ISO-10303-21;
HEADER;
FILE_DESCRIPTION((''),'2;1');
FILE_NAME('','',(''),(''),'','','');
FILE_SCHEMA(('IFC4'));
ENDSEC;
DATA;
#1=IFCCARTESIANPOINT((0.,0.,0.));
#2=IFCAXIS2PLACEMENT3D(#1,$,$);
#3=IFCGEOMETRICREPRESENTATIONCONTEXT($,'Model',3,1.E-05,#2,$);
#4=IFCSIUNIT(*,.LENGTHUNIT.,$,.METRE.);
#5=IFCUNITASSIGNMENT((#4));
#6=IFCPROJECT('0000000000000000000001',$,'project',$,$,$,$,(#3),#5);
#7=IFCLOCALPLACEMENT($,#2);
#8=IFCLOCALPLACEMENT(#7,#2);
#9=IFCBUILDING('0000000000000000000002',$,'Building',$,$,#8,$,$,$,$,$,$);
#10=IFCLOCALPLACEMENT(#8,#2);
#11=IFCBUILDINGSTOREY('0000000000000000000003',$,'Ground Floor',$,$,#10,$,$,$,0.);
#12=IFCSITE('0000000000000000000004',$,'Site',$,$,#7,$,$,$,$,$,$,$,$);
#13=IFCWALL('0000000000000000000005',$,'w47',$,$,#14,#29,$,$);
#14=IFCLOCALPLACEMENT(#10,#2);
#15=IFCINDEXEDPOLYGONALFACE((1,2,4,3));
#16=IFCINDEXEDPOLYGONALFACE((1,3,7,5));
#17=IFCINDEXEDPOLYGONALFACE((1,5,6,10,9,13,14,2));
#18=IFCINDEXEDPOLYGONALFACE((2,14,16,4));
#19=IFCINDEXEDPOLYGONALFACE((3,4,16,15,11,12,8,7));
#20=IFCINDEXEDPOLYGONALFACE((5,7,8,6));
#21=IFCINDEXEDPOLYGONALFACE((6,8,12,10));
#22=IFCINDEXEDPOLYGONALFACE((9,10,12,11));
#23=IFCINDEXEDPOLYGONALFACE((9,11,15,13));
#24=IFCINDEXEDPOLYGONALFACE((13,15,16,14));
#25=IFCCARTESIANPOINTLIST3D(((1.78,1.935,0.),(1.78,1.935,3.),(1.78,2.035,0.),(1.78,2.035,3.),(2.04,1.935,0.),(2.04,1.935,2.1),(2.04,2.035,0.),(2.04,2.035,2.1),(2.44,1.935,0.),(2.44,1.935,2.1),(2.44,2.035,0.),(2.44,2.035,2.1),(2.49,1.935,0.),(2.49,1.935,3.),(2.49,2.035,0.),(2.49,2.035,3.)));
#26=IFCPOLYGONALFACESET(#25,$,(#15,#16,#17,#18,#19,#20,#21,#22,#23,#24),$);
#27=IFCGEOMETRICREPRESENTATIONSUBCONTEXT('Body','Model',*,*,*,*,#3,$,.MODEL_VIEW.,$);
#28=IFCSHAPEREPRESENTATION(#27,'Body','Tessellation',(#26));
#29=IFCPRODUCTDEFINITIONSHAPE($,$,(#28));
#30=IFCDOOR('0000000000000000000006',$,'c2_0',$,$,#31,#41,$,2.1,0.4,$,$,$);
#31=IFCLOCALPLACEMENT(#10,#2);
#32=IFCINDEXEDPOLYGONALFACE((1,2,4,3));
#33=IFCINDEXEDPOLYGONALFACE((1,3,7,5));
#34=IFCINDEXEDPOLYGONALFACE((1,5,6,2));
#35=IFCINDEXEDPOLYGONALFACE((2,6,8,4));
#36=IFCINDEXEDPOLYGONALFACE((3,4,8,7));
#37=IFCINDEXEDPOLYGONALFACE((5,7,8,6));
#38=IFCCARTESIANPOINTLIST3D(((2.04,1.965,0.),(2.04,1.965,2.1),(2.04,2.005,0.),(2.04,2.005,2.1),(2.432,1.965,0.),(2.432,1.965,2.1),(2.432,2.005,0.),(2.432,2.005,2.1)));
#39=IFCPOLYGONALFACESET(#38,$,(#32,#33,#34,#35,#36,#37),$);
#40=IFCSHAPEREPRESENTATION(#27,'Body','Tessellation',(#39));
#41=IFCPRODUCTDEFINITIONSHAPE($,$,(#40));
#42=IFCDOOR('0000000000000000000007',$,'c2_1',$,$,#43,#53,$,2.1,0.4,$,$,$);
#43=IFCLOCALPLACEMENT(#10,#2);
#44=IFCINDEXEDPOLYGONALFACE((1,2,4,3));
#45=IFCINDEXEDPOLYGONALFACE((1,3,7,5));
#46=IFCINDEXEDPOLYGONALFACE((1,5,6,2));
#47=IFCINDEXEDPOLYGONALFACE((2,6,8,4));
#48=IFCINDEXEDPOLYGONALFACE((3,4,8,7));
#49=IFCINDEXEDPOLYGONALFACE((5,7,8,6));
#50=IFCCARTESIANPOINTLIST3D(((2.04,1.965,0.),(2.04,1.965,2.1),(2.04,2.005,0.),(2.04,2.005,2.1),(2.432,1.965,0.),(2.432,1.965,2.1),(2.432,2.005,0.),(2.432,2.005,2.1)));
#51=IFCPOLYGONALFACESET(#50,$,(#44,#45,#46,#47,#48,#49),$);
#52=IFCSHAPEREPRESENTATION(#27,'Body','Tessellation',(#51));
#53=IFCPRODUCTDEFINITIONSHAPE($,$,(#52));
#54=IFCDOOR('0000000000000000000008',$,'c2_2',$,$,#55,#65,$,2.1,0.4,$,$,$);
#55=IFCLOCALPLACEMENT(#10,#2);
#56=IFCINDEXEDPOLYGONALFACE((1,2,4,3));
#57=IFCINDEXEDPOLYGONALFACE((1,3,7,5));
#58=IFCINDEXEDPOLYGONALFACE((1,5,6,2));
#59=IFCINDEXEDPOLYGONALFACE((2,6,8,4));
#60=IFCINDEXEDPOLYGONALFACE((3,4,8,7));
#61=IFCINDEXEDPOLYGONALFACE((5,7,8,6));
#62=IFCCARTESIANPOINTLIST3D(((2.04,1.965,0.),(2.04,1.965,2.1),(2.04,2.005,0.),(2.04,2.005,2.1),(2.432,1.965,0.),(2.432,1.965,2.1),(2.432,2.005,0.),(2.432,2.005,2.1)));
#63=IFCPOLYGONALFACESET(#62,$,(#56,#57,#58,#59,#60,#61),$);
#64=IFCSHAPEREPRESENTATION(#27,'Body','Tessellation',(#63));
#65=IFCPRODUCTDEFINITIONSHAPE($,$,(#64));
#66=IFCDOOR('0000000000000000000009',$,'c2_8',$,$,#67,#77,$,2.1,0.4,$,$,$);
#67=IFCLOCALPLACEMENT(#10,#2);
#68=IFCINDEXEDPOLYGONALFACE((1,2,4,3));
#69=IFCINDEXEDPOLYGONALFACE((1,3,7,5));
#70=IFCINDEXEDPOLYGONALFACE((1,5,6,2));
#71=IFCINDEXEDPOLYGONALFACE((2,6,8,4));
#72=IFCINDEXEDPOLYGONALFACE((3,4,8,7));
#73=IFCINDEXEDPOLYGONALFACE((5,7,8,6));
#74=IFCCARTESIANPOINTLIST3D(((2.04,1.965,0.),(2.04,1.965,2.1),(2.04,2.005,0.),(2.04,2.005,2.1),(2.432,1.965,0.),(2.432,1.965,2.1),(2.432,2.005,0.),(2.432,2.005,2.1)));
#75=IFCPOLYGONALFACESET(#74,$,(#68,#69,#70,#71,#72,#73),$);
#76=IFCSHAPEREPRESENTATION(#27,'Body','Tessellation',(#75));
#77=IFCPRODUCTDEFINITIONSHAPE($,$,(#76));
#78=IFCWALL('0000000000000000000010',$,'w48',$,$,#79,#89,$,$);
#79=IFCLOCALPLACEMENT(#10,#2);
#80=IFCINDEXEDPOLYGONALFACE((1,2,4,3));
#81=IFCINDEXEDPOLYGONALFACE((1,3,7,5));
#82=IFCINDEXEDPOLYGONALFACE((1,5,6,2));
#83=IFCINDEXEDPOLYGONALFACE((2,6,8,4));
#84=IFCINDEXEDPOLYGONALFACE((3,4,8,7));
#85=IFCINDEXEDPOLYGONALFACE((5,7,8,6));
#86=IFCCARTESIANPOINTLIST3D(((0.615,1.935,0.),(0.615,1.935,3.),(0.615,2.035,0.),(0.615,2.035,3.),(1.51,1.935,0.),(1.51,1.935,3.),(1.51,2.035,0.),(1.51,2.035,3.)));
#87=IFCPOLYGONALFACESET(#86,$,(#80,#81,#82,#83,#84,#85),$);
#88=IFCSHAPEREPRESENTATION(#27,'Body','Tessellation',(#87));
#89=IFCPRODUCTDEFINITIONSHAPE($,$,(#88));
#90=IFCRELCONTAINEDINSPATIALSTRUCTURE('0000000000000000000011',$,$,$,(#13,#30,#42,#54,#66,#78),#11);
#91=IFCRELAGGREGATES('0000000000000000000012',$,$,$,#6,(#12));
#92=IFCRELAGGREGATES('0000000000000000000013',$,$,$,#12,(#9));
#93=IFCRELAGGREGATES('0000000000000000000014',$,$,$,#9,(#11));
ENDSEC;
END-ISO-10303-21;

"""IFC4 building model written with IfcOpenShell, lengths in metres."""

from ifc_helpers import new_model, si_unit, frame, origin, place, context, subcontext, project, spatial, polyline, outline, extrude, element, fill, save


model = new_model("IFC4")

# Units and contexts
model_context = context("Model", 3, precision=1e-05, world=origin())
body_context = subcontext(model_context, "Body", "Model", "MODEL_VIEW")
ifc_project = project(units=[si_unit("LENGTHUNIT", "METRE")], contexts=[model_context])

# Site, building, storey
site_placement = place(None, origin())
site = spatial("IfcSite", under=ifc_project, at=site_placement, Name="Site")
building_placement = place(site_placement, origin())
building = spatial("IfcBuilding", under=site, at=building_placement, Name="Building")
storey_placement = place(building_placement, origin())
storey = spatial("IfcBuildingStorey", under=building, at=storey_placement, Name="Ground Floor", Elevation=0.0)

# Wall, openings, doors
wall_1_placement = place(storey_placement, frame((1.78, 1.985, 0.0), x_axis=(1.0, 0.0, 0.0)))
wall_1 = element("IfcWall", 1, at=wall_1_placement, inside=storey, Name="w47", context=body_context, shape_type="SweptSolid", body=[
    extrude(outline(polyline([(0.0, -0.05), (0.71, -0.05), (0.71, 0.05), (0.0, 0.05), (0.0, -0.05)])), origin(), (0.0, 0.0, 1.0), 3.0),
])
opening_1_placement = place(wall_1_placement, frame((0.26, 0.0, 0.0)))
opening_1 = element("IfcOpeningElement", 2, at=opening_1_placement, cuts=wall_1, context=body_context, shape_type="SweptSolid", body=[
    extrude(outline(polyline([(0.0, -0.0525), (0.4, -0.0525), (0.4, 0.0525), (0.0, 0.0525), (0.0, -0.0525)])), origin(), (0.0, 0.0, 1.0), 2.1),
])
opening_2_placement = place(wall_1_placement, frame((0.26, 0.0, 0.0)))
opening_2 = element("IfcOpeningElement", 3, at=opening_2_placement, cuts=wall_1, context=body_context, shape_type="SweptSolid", body=[
    extrude(outline(polyline([(0.0, -0.0525), (0.4, -0.0525), (0.4, 0.0525), (0.0, 0.0525), (0.0, -0.0525)])), origin(), (0.0, 0.0, 1.0), 2.1),
])
opening_3_placement = place(wall_1_placement, frame((0.26, 0.0, 0.0)))
opening_3 = element("IfcOpeningElement", 4, at=opening_3_placement, cuts=wall_1, context=body_context, shape_type="SweptSolid", body=[
    extrude(outline(polyline([(0.0, -0.0525), (0.4, -0.0525), (0.4, 0.0525), (0.0, 0.0525), (0.0, -0.0525)])), origin(), (0.0, 0.0, 1.0), 2.1),
])
opening_4_placement = place(wall_1_placement, frame((0.26, 0.0, 0.0)))
opening_4 = element("IfcOpeningElement", 5, at=opening_4_placement, cuts=wall_1, context=body_context, shape_type="SweptSolid", body=[
    extrude(outline(polyline([(0.0, -0.0525), (0.4, -0.0525), (0.4, 0.0525), (0.0, 0.0525), (0.0, -0.0525)])), origin(), (0.0, 0.0, 1.0), 2.1),
])
door_1_placement = place(wall_1_placement, frame((0.26, 0.0, 0.0)))
door_1 = element("IfcDoor", 6, at=door_1_placement, inside=storey, Name="c2_0", OverallHeight=2.1, OverallWidth=0.4, context=body_context, shape_type="SweptSolid", body=[
    extrude(outline(polyline([(0.0, -0.02), (0.392, -0.02), (0.392, 0.02), (0.0, 0.02), (0.0, -0.02)])), origin(), (0.0, 0.0, 1.0), 2.1),
])
fill(opening_1, door_1)
door_2_placement = place(wall_1_placement, frame((0.26, 0.0, 0.0)))
door_2 = element("IfcDoor", 7, at=door_2_placement, inside=storey, Name="c2_1", OverallHeight=2.1, OverallWidth=0.4, context=body_context, shape_type="SweptSolid", body=[
    extrude(outline(polyline([(0.0, -0.02), (0.392, -0.02), (0.392, 0.02), (0.0, 0.02), (0.0, -0.02)])), origin(), (0.0, 0.0, 1.0), 2.1),
])
fill(opening_2, door_2)
door_3_placement = place(wall_1_placement, frame((0.26, 0.0, 0.0)))
door_3 = element("IfcDoor", 8, at=door_3_placement, inside=storey, Name="c2_2", OverallHeight=2.1, OverallWidth=0.4, context=body_context, shape_type="SweptSolid", body=[
    extrude(outline(polyline([(0.0, -0.02), (0.392, -0.02), (0.392, 0.02), (0.0, 0.02), (0.0, -0.02)])), origin(), (0.0, 0.0, 1.0), 2.1),
])
fill(opening_3, door_3)
door_4_placement = place(wall_1_placement, frame((0.26, 0.0, 0.0)))
door_4 = element("IfcDoor", 9, at=door_4_placement, inside=storey, Name="c2_8", OverallHeight=2.1, OverallWidth=0.4, context=body_context, shape_type="SweptSolid", body=[
    extrude(outline(polyline([(0.0, -0.02), (0.392, -0.02), (0.392, 0.02), (0.0, 0.02), (0.0, -0.02)])), origin(), (0.0, 0.0, 1.0), 2.1),
])
fill(opening_4, door_4)

# Wall
wall_2_placement = place(storey_placement, frame((0.615, 1.985, 0.0), x_axis=(1.0, 0.0, 0.0)))
element("IfcWall", 10, at=wall_2_placement, inside=storey, Name="w48", context=body_context, shape_type="SweptSolid", body=[
    extrude(outline(polyline([(0.0, -0.05), (0.895, -0.05), (0.895, 0.05), (0.0, 0.05), (0.0, -0.05)])), origin(), (0.0, 0.0, 1.0), 3.0),
])

save(model, "model.ifc")
